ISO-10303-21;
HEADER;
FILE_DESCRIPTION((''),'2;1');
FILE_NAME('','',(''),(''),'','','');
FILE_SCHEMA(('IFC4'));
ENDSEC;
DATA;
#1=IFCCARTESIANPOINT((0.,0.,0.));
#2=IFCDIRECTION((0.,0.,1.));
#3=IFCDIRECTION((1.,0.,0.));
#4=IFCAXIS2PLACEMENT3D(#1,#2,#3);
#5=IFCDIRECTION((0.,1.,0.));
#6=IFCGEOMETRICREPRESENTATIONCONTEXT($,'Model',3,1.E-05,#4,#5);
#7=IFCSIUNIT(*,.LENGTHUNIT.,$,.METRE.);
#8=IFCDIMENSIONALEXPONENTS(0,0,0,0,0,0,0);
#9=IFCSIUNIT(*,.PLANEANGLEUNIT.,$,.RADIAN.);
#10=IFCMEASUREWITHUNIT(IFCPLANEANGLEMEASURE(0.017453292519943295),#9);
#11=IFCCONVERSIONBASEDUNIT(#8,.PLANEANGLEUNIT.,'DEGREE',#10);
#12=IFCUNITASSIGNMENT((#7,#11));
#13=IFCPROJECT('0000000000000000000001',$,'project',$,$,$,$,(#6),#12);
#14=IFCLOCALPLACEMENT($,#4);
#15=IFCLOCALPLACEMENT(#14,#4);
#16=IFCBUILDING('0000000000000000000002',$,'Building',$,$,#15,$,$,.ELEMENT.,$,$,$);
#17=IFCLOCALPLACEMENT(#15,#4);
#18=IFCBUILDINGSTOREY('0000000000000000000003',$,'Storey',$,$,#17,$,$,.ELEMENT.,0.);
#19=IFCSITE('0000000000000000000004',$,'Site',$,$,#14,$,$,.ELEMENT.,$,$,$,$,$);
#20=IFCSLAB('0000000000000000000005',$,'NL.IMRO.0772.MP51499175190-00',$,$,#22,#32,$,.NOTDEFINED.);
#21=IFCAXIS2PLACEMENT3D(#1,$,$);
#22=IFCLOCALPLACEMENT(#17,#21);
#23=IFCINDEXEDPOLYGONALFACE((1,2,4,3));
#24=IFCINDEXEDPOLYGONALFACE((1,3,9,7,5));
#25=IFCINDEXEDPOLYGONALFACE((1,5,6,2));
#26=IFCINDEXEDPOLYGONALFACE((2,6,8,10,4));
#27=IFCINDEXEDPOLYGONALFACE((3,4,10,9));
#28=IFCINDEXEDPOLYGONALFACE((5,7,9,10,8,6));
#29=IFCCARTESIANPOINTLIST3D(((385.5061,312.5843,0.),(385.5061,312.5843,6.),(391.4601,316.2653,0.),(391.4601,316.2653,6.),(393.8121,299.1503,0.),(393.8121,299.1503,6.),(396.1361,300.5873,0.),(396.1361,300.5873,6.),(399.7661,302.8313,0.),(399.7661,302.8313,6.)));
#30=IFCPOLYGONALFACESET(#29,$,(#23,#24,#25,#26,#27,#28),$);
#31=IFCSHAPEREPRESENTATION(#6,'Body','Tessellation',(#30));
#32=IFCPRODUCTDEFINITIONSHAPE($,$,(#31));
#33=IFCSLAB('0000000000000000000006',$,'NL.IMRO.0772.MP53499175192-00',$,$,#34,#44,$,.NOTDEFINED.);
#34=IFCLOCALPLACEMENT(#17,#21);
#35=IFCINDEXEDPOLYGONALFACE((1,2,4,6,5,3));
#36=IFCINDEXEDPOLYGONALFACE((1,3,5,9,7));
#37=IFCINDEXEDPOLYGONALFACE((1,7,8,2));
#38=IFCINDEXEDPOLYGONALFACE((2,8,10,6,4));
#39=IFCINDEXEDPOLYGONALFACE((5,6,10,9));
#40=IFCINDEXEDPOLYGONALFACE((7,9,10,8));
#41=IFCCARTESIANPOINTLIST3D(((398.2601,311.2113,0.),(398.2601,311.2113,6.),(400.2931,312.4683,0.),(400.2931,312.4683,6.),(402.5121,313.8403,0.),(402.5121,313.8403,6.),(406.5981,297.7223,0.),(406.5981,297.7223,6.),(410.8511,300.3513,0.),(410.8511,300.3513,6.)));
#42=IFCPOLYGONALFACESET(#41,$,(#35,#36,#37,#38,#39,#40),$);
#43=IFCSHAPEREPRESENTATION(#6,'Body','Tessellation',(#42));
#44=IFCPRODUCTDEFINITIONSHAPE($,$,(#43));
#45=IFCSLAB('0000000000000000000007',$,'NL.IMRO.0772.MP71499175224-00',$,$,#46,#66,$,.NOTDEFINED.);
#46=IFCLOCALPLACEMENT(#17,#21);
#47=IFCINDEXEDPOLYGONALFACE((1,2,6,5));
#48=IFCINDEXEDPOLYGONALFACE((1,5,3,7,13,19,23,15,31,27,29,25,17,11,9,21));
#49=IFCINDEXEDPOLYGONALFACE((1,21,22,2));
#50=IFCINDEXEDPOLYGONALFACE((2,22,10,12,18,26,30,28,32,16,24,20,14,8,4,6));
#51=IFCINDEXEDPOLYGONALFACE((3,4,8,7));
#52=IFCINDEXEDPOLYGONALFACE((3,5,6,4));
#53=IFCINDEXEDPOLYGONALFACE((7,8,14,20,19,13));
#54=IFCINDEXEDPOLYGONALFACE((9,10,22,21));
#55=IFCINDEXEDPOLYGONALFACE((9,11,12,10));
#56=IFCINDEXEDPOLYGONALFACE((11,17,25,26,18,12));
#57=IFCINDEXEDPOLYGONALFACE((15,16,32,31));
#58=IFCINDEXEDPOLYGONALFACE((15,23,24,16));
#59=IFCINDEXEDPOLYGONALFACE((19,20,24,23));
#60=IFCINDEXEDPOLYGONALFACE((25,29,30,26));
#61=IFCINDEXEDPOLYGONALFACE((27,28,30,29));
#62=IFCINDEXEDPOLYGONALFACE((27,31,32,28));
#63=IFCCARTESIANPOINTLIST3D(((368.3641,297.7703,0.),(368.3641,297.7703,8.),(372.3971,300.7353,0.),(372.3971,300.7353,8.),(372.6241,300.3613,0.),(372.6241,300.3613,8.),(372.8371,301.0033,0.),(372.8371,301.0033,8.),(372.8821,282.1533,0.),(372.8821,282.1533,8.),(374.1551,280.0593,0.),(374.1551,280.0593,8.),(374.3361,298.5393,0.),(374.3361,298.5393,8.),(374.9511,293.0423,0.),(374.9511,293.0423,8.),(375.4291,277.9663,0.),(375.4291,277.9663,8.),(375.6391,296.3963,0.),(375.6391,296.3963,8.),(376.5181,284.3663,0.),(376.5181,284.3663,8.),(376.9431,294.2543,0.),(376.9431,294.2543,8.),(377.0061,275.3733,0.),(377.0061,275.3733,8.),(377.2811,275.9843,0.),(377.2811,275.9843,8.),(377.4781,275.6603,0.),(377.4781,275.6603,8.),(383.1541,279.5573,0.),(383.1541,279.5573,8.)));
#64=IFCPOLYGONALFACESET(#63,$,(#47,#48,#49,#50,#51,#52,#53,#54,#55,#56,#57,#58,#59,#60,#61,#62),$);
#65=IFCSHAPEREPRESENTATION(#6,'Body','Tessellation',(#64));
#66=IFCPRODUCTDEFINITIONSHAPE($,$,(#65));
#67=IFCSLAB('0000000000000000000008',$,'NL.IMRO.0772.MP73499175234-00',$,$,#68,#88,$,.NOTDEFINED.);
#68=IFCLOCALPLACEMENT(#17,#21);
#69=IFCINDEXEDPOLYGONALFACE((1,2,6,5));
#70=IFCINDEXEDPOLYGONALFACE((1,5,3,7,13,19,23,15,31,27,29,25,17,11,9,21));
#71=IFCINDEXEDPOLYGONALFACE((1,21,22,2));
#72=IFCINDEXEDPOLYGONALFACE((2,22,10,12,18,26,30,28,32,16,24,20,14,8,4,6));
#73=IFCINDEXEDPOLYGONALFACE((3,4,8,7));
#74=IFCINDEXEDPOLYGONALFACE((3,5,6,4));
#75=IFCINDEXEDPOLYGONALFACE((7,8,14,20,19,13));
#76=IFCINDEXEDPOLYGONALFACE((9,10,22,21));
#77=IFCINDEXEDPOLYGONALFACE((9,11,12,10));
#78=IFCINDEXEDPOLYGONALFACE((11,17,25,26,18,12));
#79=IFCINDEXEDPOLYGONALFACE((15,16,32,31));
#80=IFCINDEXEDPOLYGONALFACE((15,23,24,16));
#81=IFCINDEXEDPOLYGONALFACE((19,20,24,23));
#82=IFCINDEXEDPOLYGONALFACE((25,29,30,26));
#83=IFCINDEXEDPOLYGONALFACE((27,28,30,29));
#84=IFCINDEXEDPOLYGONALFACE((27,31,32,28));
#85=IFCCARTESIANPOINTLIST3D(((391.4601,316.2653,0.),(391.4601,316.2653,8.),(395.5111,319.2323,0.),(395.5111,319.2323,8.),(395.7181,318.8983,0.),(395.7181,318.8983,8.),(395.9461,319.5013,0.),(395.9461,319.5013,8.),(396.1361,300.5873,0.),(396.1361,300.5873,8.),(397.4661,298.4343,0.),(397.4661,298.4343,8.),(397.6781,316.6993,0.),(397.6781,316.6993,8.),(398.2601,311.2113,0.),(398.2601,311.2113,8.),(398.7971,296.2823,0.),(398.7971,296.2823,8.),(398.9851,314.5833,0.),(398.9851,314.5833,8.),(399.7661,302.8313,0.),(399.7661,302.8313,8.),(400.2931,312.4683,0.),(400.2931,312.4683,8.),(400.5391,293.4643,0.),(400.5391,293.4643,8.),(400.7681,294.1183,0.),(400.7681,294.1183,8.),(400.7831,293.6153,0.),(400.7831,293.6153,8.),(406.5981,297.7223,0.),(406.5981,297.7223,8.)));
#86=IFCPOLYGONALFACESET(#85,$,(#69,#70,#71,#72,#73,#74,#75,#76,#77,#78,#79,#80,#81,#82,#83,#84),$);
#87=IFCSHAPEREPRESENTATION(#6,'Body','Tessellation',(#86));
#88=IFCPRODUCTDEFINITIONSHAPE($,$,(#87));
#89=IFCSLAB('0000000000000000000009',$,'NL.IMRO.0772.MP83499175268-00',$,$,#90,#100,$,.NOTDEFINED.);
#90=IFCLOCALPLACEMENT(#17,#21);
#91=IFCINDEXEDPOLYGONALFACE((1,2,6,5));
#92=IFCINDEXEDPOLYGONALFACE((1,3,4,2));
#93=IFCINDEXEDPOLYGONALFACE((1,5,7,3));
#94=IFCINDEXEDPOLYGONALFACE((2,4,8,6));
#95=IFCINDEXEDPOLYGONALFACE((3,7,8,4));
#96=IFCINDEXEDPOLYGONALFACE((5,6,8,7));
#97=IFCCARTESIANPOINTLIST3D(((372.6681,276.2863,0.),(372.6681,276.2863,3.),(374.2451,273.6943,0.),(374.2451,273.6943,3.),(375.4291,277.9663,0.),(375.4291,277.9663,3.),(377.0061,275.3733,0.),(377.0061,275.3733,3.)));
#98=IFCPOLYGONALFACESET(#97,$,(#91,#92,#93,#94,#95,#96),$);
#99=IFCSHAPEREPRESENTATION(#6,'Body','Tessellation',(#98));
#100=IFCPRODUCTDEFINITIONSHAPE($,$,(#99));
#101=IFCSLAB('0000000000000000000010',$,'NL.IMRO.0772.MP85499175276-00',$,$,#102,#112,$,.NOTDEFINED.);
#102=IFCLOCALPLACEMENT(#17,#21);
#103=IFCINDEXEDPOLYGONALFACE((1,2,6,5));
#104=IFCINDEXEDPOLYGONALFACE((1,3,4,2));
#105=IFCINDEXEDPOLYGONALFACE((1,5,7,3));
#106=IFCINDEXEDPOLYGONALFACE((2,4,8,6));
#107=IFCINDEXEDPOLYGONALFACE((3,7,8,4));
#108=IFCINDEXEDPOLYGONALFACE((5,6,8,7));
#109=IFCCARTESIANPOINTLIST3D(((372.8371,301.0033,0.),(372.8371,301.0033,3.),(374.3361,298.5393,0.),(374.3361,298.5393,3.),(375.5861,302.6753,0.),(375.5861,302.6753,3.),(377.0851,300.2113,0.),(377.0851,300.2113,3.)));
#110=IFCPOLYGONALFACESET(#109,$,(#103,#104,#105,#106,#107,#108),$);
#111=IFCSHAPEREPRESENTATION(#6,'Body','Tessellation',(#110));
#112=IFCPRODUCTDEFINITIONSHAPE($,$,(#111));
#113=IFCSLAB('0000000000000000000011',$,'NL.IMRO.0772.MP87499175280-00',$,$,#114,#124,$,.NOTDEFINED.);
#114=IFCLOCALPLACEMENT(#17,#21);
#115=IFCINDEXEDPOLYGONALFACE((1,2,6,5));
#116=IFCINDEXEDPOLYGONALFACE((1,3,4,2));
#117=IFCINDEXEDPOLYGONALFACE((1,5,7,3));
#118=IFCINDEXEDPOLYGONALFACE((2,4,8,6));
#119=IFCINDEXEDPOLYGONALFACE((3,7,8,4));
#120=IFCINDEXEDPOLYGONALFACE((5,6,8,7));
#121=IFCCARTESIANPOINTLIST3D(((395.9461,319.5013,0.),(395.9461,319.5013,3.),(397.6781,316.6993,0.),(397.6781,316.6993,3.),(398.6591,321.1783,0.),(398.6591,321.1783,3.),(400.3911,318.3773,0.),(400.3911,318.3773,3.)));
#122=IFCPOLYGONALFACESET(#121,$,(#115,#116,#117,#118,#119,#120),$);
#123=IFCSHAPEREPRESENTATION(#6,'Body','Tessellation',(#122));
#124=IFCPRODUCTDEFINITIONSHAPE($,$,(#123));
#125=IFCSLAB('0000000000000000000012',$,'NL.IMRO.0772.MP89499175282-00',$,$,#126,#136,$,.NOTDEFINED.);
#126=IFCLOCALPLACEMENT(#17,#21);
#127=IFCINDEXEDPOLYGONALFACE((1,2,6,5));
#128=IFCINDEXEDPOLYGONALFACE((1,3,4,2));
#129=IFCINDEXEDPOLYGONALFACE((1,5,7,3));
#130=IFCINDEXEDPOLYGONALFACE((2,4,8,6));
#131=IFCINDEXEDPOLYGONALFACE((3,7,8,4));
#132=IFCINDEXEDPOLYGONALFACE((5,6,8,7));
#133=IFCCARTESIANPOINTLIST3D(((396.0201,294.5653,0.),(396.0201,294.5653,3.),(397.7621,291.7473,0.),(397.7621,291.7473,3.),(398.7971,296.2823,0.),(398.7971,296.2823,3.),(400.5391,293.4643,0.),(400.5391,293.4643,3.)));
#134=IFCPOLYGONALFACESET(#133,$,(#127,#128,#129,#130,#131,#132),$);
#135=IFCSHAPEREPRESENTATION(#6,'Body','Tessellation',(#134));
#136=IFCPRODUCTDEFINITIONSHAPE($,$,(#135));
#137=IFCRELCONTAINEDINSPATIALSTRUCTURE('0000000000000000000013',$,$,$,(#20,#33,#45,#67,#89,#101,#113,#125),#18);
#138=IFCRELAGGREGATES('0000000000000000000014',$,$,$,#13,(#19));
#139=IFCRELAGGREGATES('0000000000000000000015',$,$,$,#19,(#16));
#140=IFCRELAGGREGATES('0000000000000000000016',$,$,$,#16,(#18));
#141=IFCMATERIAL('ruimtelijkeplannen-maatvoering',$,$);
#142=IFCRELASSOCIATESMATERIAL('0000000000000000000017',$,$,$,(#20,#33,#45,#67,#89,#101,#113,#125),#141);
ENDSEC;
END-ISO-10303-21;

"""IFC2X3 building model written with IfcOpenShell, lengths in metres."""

from ifc_helpers import new_model, entity, si_unit, converted_unit, direction, origin_with_axes, place, context, project, spatial, polyline, outline, extrude, material, element, save


model = new_model("IFC2X3")

# Units and contexts
model_context = context("Model", 3, precision=1e-05, world=origin_with_axes(), true_north=direction((0.0, 1.0, 0.0)))
ifc_project = project(units=[si_unit("LENGTHUNIT", "METRE"), converted_unit("PLANEANGLEUNIT", "DEGREE", entity("IfcPlaneAngleMeasure", 0.017453292519943295), si_unit("PLANEANGLEUNIT", "RADIAN"), dimensions=[0, 0, 0, 0, 0, 0, 0])], contexts=[model_context])

# Site, building, storey
site_placement = place(None, origin_with_axes())
site = spatial("IfcSite", under=ifc_project, at=site_placement, Name="Site", CompositionType="ELEMENT")
building_placement = place(site_placement, origin_with_axes())
building = spatial("IfcBuilding", under=site, at=building_placement, Name="Building", CompositionType="ELEMENT")
storey_placement = place(building_placement, origin_with_axes())
storey = spatial("IfcBuildingStorey", under=building, at=storey_placement, Name="Storey", CompositionType="ELEMENT", Elevation=0.0)

# Slabs
ifc_material = material(Name="ruimtelijkeplannen-maatvoering")
slab_1_placement = place(storey_placement, origin_with_axes())
element("IfcSlab", 1, at=slab_1_placement, inside=storey, material=ifc_material, Name="NL.IMRO.0772.MP51499175190-00", PredefinedType="NOTDEFINED", context=model_context, shape_type="SweptSolid", body=[
    extrude(outline(polyline([(399.7661, 302.8313), (396.1361, 300.5873), (393.8121, 299.1503), (385.5061, 312.5843), (391.4601, 316.2653), (399.7661, 302.8313)])), origin_with_axes(), (0.0, 0.0, 1.0), 6.0),
])
slab_2_placement = place(storey_placement, origin_with_axes())
element("IfcSlab", 2, at=slab_2_placement, inside=storey, material=ifc_material, Name="NL.IMRO.0772.MP53499175192-00", PredefinedType="NOTDEFINED", context=model_context, shape_type="SweptSolid", body=[
    extrude(outline(polyline([(398.2601, 311.2113), (400.2931, 312.4683), (402.5121, 313.8403), (410.8511, 300.3513), (406.5981, 297.7223), (398.2601, 311.2113)])), origin_with_axes(), (0.0, 0.0, 1.0), 6.0),
])
slab_3_placement = place(storey_placement, origin_with_axes())
element("IfcSlab", 3, at=slab_3_placement, inside=storey, material=ifc_material, Name="NL.IMRO.0772.MP71499175224-00", PredefinedType="NOTDEFINED", context=model_context, shape_type="SweptSolid", body=[
    extrude(outline(polyline([(374.9511, 293.0423), (383.1541, 279.5573), (377.2811, 275.9843), (377.4781, 275.6603), (377.0061, 275.3733), (375.4291, 277.9663), (374.1551, 280.0593), (372.8821, 282.1533), (376.5181, 284.3663), (368.3641, 297.7703), (372.6241, 300.3613), (372.3971, 300.7353), (372.8371, 301.0033), (374.3361, 298.5393), (375.6391, 296.3963), (376.9431, 294.2543), (374.9511, 293.0423)])), origin_with_axes(), (0.0, 0.0, 1.0), 8.0),
])
slab_4_placement = place(storey_placement, origin_with_axes())
element("IfcSlab", 4, at=slab_4_placement, inside=storey, material=ifc_material, Name="NL.IMRO.0772.MP73499175234-00", PredefinedType="NOTDEFINED", context=model_context, shape_type="SweptSolid", body=[
    extrude(outline(polyline([(398.2601, 311.2113), (406.5981, 297.7223), (400.7681, 294.1183), (400.7831, 293.6153), (400.5391, 293.4643), (398.7971, 296.2823), (397.4661, 298.4343), (396.1361, 300.5873), (399.7661, 302.8313), (391.4601, 316.2653), (395.7181, 318.8983), (395.5111, 319.2323), (395.9461, 319.5013), (397.6781, 316.6993), (398.9851, 314.5833), (400.2931, 312.4683), (398.2601, 311.2113)])), origin_with_axes(), (0.0, 0.0, 1.0), 8.0),
])
slab_5_placement = place(storey_placement, origin_with_axes())
element("IfcSlab", 5, at=slab_5_placement, inside=storey, material=ifc_material, Name="NL.IMRO.0772.MP83499175268-00", PredefinedType="NOTDEFINED", context=model_context, shape_type="SweptSolid", body=[
    extrude(outline(polyline([(377.0061, 275.3733), (374.2451, 273.6943), (372.6681, 276.2863), (375.4291, 277.9663), (377.0061, 275.3733)])), origin_with_axes(), (0.0, 0.0, 1.0), 3.0),
])
slab_6_placement = place(storey_placement, origin_with_axes())
element("IfcSlab", 6, at=slab_6_placement, inside=storey, material=ifc_material, Name="NL.IMRO.0772.MP85499175276-00", PredefinedType="NOTDEFINED", context=model_context, shape_type="SweptSolid", body=[
    extrude(outline(polyline([(372.8371, 301.0033), (375.5861, 302.6753), (377.0851, 300.2113), (374.3361, 298.5393), (372.8371, 301.0033)])), origin_with_axes(), (0.0, 0.0, 1.0), 3.0),
])
slab_7_placement = place(storey_placement, origin_with_axes())
element("IfcSlab", 7, at=slab_7_placement, inside=storey, material=ifc_material, Name="NL.IMRO.0772.MP87499175280-00", PredefinedType="NOTDEFINED", context=model_context, shape_type="SweptSolid", body=[
    extrude(outline(polyline([(395.9461, 319.5013), (398.6591, 321.1783), (400.3911, 318.3773), (397.6781, 316.6993), (395.9461, 319.5013)])), origin_with_axes(), (0.0, 0.0, 1.0), 3.0),
])
slab_8_placement = place(storey_placement, origin_with_axes())
element("IfcSlab", 8, at=slab_8_placement, inside=storey, material=ifc_material, Name="NL.IMRO.0772.MP89499175282-00", PredefinedType="NOTDEFINED", context=model_context, shape_type="SweptSolid", body=[
    extrude(outline(polyline([(400.5391, 293.4643), (397.7621, 291.7473), (396.0201, 294.5653), (398.7971, 296.2823), (400.5391, 293.4643)])), origin_with_axes(), (0.0, 0.0, 1.0), 3.0),
])

save(model, "model.ifc")
